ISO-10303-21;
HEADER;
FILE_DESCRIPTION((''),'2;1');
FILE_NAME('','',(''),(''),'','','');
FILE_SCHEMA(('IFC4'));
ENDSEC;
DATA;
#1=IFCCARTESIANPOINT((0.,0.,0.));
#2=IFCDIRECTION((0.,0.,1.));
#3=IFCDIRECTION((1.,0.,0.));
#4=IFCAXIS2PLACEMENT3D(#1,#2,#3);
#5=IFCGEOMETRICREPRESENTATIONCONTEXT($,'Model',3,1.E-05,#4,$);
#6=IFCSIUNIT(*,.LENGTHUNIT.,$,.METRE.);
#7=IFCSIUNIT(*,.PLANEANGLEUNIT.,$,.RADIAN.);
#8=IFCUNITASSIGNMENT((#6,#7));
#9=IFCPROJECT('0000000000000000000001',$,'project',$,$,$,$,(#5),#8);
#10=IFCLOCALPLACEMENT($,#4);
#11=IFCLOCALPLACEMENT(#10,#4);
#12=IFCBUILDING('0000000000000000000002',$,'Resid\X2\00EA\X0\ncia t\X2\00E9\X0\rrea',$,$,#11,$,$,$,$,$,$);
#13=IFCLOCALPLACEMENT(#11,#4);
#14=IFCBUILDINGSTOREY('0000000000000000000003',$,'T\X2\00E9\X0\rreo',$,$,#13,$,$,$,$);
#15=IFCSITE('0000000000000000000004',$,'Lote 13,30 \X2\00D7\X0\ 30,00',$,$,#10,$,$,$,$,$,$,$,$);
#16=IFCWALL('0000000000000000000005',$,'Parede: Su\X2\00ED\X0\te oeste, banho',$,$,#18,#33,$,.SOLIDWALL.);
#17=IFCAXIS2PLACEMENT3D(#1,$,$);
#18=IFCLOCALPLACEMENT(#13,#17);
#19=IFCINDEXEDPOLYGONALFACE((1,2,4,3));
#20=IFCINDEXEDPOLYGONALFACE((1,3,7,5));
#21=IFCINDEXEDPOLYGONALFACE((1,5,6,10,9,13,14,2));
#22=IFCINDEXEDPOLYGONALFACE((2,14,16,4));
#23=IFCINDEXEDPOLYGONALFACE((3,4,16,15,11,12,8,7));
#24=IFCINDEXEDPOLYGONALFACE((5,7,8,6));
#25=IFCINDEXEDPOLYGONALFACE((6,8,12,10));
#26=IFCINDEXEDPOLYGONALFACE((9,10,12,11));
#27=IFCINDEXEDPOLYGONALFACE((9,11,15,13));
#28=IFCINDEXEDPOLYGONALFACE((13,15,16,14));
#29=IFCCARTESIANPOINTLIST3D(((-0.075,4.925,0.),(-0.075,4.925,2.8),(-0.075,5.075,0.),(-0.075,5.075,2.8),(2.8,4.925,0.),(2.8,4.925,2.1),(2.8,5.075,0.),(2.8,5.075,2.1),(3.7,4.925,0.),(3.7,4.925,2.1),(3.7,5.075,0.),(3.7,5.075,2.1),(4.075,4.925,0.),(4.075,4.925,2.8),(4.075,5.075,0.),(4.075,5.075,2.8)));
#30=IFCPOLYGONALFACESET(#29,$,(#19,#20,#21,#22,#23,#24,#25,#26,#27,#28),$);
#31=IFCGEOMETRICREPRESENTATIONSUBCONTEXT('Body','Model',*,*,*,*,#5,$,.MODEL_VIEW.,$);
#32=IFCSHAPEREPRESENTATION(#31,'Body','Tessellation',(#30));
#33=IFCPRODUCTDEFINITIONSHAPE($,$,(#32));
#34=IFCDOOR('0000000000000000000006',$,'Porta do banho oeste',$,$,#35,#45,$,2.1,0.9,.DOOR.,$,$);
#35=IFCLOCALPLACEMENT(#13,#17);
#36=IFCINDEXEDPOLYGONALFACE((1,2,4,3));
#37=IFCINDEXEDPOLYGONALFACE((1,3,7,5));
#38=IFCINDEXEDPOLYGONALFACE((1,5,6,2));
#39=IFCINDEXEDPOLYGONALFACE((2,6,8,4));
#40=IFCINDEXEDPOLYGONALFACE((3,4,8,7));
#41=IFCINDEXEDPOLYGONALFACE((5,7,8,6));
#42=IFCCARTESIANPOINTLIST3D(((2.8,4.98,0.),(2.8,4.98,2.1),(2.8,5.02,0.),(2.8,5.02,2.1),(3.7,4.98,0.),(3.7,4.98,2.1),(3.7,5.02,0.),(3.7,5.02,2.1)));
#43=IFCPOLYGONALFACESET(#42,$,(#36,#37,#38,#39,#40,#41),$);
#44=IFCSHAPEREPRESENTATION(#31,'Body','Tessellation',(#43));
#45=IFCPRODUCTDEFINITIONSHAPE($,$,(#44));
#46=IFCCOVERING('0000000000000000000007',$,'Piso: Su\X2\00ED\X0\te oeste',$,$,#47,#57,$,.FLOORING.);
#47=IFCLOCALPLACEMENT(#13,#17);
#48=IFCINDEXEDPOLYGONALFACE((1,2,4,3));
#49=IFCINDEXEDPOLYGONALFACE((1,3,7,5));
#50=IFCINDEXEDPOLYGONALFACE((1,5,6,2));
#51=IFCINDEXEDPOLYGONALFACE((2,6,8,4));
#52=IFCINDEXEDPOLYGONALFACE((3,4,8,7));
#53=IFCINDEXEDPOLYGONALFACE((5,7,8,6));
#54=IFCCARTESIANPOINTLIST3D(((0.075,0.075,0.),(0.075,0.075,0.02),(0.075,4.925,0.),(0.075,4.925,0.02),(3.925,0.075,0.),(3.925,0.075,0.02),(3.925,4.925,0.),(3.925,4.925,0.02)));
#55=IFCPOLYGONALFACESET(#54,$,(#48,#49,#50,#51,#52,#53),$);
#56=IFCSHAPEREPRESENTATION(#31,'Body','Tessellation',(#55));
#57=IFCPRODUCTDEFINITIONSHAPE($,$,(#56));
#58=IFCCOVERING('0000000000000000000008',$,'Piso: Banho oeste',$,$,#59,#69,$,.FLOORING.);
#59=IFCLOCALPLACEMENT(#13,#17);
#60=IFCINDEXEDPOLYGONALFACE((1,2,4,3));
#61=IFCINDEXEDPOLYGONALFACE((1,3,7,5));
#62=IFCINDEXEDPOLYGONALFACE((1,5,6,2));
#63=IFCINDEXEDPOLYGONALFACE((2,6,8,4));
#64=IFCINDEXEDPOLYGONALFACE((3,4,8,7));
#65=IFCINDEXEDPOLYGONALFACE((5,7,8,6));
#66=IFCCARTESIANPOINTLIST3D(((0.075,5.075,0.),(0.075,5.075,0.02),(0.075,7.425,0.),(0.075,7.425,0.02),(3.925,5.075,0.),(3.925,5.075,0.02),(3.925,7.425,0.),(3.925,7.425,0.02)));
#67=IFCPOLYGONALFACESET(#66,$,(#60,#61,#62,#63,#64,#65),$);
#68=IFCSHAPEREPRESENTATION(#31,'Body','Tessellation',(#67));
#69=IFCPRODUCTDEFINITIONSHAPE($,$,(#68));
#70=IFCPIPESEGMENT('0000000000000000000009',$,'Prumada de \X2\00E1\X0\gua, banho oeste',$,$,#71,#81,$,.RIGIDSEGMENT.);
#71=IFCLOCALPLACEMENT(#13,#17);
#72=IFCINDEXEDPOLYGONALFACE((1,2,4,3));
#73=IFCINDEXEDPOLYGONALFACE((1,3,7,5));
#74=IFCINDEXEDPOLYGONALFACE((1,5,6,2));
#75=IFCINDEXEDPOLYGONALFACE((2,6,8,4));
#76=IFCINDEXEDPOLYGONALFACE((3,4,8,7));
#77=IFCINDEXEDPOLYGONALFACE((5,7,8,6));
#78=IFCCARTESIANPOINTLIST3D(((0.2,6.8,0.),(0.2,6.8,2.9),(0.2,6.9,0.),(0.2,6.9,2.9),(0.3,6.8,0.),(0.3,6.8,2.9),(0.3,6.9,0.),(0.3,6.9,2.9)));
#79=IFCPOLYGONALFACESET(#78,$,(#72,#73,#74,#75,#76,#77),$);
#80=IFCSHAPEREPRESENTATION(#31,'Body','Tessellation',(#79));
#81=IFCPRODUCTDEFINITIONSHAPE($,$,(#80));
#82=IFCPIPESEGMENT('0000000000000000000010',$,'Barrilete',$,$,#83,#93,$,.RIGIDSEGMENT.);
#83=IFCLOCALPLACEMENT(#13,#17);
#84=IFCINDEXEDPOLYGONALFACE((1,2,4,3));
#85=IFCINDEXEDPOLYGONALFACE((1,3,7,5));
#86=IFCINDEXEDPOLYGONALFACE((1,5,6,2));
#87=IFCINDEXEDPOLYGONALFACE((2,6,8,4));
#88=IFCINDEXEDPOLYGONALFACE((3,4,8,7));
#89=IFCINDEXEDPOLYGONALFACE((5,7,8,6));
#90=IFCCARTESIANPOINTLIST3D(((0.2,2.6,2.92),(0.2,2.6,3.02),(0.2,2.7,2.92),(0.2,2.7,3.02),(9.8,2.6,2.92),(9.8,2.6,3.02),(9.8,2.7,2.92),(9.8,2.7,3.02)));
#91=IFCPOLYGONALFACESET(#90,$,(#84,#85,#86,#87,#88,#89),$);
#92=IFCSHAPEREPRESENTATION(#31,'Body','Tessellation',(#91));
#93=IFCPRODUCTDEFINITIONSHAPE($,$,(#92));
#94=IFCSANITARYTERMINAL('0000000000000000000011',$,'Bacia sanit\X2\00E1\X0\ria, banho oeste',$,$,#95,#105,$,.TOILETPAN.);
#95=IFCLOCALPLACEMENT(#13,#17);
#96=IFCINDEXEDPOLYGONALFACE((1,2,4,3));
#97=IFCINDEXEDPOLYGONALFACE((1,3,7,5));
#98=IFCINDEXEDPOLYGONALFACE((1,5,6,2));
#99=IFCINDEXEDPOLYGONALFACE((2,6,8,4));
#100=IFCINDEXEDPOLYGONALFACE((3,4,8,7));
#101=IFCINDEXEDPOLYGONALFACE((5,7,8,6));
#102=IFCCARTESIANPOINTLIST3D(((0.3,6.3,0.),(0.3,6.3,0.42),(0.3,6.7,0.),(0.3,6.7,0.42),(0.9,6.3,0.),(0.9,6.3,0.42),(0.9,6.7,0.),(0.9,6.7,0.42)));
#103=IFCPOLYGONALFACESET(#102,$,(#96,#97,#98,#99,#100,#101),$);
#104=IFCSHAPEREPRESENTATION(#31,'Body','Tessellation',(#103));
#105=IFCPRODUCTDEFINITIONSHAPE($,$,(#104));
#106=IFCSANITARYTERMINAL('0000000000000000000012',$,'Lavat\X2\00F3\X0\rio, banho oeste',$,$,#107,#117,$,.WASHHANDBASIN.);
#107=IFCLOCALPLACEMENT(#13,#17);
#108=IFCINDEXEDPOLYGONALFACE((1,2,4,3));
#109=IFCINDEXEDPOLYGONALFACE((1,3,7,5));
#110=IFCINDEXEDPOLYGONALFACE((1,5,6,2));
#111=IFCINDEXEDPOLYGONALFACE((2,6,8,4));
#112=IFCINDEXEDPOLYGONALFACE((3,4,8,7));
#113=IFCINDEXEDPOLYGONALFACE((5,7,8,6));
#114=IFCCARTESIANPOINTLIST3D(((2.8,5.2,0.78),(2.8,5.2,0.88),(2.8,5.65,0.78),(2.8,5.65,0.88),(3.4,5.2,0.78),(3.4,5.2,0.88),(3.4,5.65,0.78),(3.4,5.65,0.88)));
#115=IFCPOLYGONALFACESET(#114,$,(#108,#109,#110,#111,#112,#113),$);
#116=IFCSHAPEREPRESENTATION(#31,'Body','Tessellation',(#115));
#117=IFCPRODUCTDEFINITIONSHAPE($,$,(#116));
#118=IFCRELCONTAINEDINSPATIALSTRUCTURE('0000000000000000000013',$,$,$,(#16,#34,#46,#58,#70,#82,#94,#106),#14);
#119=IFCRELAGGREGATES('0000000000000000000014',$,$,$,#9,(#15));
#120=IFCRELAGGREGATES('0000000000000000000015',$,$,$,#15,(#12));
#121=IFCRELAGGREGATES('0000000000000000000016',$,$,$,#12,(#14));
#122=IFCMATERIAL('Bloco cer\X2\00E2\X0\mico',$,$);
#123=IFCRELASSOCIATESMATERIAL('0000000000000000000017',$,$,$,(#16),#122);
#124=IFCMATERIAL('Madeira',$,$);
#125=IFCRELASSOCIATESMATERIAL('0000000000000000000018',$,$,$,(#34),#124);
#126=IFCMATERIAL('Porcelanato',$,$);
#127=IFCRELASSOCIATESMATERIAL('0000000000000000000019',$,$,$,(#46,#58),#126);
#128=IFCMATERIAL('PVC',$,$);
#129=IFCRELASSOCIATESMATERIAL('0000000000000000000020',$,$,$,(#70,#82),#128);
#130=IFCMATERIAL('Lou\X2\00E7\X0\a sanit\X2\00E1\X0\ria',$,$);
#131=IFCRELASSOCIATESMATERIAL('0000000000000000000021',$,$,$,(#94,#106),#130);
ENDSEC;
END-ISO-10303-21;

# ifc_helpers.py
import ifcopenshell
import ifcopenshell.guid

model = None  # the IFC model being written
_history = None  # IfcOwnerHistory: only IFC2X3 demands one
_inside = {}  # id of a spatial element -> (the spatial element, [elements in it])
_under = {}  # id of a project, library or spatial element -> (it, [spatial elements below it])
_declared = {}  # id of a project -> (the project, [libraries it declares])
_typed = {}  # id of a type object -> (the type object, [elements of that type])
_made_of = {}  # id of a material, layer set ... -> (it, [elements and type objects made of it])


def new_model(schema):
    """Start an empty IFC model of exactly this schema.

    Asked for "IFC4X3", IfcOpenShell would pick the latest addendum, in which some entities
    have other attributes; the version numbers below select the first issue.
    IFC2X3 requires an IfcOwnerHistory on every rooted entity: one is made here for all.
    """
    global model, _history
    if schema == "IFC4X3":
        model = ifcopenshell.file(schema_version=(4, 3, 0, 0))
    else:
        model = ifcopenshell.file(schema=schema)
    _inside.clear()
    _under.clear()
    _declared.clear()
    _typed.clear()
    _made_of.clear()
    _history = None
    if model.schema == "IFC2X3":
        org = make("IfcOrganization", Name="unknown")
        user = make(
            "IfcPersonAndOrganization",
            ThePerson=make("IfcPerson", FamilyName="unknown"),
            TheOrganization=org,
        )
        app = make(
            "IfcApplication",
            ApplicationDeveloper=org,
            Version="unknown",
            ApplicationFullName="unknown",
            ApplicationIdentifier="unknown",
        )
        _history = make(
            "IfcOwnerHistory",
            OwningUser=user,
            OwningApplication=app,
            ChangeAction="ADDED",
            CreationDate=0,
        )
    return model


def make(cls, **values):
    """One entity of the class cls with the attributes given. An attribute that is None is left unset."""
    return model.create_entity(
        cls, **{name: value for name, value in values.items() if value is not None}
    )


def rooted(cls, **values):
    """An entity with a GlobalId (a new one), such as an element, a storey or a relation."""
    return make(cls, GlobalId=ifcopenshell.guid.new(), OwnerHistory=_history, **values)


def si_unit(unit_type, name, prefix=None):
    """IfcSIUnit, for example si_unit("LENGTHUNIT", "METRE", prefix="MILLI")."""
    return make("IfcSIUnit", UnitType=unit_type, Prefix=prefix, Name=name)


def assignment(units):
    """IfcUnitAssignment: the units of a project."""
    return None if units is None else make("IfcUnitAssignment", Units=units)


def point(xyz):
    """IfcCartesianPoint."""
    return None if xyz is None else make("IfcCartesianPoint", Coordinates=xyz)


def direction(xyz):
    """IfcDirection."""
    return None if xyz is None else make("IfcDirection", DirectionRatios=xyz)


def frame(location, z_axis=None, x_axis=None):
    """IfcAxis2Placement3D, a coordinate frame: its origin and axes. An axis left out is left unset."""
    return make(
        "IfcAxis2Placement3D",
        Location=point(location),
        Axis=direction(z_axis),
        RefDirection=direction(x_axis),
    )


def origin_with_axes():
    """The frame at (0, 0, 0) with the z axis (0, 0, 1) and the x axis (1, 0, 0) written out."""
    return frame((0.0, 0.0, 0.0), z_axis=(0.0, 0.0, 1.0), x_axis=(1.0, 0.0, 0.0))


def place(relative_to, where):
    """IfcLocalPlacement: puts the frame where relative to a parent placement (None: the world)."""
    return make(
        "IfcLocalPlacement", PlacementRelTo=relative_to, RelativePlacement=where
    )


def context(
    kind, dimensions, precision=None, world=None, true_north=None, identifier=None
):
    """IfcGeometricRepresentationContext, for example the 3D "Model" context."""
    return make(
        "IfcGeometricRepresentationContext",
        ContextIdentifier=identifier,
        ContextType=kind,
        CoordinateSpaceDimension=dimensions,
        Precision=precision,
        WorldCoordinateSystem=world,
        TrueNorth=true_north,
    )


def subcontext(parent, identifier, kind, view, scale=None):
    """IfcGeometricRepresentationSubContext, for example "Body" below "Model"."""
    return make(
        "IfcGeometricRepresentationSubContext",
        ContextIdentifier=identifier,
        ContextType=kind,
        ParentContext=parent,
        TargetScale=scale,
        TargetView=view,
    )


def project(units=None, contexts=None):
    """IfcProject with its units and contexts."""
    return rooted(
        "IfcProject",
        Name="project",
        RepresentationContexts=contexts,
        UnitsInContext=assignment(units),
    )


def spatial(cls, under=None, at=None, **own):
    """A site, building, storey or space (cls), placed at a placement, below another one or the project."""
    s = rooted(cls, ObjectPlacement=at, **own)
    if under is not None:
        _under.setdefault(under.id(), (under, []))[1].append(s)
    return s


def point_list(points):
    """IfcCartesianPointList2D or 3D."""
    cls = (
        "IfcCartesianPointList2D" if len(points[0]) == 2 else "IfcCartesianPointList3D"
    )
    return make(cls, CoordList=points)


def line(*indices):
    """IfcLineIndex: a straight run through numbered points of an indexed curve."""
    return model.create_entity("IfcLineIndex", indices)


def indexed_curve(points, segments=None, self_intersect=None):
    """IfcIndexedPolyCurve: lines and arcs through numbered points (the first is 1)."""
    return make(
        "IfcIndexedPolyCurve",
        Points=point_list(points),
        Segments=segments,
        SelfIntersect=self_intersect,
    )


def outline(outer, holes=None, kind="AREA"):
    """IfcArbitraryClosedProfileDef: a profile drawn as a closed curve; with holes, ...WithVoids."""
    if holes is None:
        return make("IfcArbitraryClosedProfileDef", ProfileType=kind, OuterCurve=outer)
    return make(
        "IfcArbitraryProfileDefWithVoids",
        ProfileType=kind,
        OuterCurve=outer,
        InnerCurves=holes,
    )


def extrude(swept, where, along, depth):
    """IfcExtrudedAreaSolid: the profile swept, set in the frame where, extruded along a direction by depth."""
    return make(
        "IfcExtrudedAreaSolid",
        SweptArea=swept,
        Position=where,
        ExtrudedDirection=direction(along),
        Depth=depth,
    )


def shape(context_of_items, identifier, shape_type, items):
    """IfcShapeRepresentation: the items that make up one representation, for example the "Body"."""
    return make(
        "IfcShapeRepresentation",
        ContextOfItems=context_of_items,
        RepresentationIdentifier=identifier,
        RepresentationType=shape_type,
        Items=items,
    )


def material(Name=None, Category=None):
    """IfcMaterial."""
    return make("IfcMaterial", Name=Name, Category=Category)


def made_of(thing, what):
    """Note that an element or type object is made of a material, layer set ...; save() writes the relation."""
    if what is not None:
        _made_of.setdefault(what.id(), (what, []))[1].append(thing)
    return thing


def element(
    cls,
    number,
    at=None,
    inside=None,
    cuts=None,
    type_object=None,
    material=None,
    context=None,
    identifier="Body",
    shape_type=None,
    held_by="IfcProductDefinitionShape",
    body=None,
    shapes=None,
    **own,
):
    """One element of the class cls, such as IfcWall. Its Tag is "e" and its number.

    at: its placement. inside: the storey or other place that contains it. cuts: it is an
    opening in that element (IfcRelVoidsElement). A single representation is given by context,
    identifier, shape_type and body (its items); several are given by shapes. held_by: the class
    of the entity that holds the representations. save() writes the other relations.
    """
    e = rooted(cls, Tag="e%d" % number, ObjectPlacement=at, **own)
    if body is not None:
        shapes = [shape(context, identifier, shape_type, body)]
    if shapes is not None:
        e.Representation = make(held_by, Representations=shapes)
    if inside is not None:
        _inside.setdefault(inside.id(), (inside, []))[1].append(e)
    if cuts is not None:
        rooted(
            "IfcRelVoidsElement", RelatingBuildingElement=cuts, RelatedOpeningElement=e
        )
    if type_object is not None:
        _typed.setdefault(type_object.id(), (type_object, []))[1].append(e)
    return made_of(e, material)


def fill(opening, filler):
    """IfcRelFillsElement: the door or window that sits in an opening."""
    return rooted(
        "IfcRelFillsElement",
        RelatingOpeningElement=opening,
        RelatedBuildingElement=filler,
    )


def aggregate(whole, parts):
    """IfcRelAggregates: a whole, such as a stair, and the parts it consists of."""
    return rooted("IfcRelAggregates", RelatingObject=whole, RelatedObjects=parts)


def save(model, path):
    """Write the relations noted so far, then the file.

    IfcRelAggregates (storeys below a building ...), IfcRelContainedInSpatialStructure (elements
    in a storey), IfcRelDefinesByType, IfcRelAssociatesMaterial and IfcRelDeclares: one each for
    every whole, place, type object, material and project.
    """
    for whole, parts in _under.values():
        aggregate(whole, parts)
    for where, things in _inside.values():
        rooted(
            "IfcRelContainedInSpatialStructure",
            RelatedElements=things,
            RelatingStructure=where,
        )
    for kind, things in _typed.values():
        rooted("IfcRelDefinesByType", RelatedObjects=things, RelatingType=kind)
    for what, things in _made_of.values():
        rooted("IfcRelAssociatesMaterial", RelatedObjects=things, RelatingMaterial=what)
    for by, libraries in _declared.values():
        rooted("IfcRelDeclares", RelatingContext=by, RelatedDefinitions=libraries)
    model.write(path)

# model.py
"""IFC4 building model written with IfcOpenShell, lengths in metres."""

from ifc_helpers import new_model, si_unit, frame, origin_with_axes, place, context, subcontext, project, spatial, line, indexed_curve, outline, extrude, material, element, fill, save


model = new_model("IFC4")

# Units and contexts
model_context = context("Model", 3, precision=1e-05, world=origin_with_axes())
body_context = subcontext(model_context, "Body", "Model", "MODEL_VIEW")
ifc_project = project(units=[si_unit("LENGTHUNIT", "METRE"), si_unit("PLANEANGLEUNIT", "RADIAN")], contexts=[model_context])

# Site, building, storey
site_placement = place(None, origin_with_axes())
site = spatial("IfcSite", under=ifc_project, at=site_placement, Name="Lote 13,30 × 30,00")
building_placement = place(site_placement, origin_with_axes())
building = spatial("IfcBuilding", under=site, at=building_placement, Name="Residência térrea")
storey_placement = place(building_placement, origin_with_axes())
storey = spatial("IfcBuildingStorey", under=building, at=storey_placement, Name="Térreo")

# Shared definitions
ifc_material_1 = material(Name="Concreto armado")

# Shared definitions
ifc_material_2 = material(Name="Bloco cerâmico")
ifc_material_3 = material(Name="Madeira")

# Wall, opening, door
wall_1_placement = place(storey_placement, frame((-0.075, 4.925, 0.0), z_axis=(0.0, 0.0, 1.0), x_axis=(1.0, 0.0, 0.0)))
wall_1 = element("IfcWall", 1, at=wall_1_placement, inside=storey, material=ifc_material_2, Name="Parede: Suíte oeste, banho", PredefinedType="SOLIDWALL", context=body_context, shape_type="SweptSolid", body=[
    extrude(outline(indexed_curve([(0.0, 0.0), (4.15, 0.0), (4.15, 0.15), (0.0, 0.15)], segments=[line(1, 2, 3, 4, 1)])), origin_with_axes(), (0.0, 0.0, 1.0), 2.8),
])
opening_1_placement = place(wall_1_placement, frame((2.875, -0.05, 0.0), z_axis=(0.0, 0.0, 1.0), x_axis=(1.0, 0.0, 0.0)))
opening_1 = element("IfcOpeningElement", 2, at=opening_1_placement, cuts=wall_1, material=ifc_material_1, PredefinedType="OPENING", context=body_context, shape_type="SweptSolid", body=[
    extrude(outline(indexed_curve([(0.0, 0.0), (0.9, 0.0), (0.9, 0.25), (0.0, 0.25)], segments=[line(1, 2, 3, 4, 1)])), origin_with_axes(), (0.0, 0.0, 1.0), 2.1),
])
door_1_placement = place(storey_placement, frame((2.8, 4.98, 0.0), z_axis=(0.0, 0.0, 1.0), x_axis=(1.0, 0.0, 0.0)))
door_1 = element("IfcDoor", 3, at=door_1_placement, inside=storey, material=ifc_material_3, Name="Porta do banho oeste", OverallHeight=2.1, OverallWidth=0.9, PredefinedType="DOOR", context=body_context, shape_type="SweptSolid", body=[
    extrude(outline(indexed_curve([(0.0, 0.0), (0.9, 0.0), (0.9, 0.04), (0.0, 0.04)], segments=[line(1, 2, 3, 4, 1)])), origin_with_axes(), (0.0, 0.0, 1.0), 2.1),
])
fill(opening_1, door_1)

# Coverings
ifc_material_4 = material(Name="Porcelanato")
covering_1_placement = place(storey_placement, frame((0.075, 0.075, 0.0), z_axis=(0.0, 0.0, 1.0), x_axis=(1.0, 0.0, 0.0)))
element("IfcCovering", 4, at=covering_1_placement, inside=storey, material=ifc_material_4, Name="Piso: Suíte oeste", PredefinedType="FLOORING", context=body_context, shape_type="SweptSolid", body=[
    extrude(outline(indexed_curve([(0.0, 0.0), (3.85, 0.0), (3.85, 4.85), (0.0, 4.85)], segments=[line(1, 2, 3, 4, 1)])), origin_with_axes(), (0.0, 0.0, 1.0), 0.02),
])
covering_2_placement = place(storey_placement, frame((0.075, 5.075, 0.0), z_axis=(0.0, 0.0, 1.0), x_axis=(1.0, 0.0, 0.0)))
element("IfcCovering", 5, at=covering_2_placement, inside=storey, material=ifc_material_4, Name="Piso: Banho oeste", PredefinedType="FLOORING", context=body_context, shape_type="SweptSolid", body=[
    extrude(outline(indexed_curve([(0.0, 0.0), (3.85, 0.0), (3.85, 2.35), (0.0, 2.35)], segments=[line(1, 2, 3, 4, 1)])), origin_with_axes(), (0.0, 0.0, 1.0), 0.02),
])

# Pipe segments
ifc_material_5 = material(Name="PVC")
pipe_segment_1_placement = place(storey_placement, frame((0.2, 6.8, 0.0), z_axis=(0.0, 0.0, 1.0), x_axis=(1.0, 0.0, 0.0)))
element("IfcPipeSegment", 6, at=pipe_segment_1_placement, inside=storey, material=ifc_material_5, Name="Prumada de água, banho oeste", PredefinedType="RIGIDSEGMENT", context=body_context, shape_type="SweptSolid", body=[
    extrude(outline(indexed_curve([(0.0, 0.0), (0.1, 0.0), (0.1, 0.1), (0.0, 0.1)], segments=[line(1, 2, 3, 4, 1)])), origin_with_axes(), (0.0, 0.0, 1.0), 2.9),
])
pipe_segment_2_placement = place(storey_placement, frame((0.2, 2.6, 2.92), z_axis=(0.0, 0.0, 1.0), x_axis=(1.0, 0.0, 0.0)))
element("IfcPipeSegment", 7, at=pipe_segment_2_placement, inside=storey, material=ifc_material_5, Name="Barrilete", PredefinedType="RIGIDSEGMENT", context=body_context, shape_type="SweptSolid", body=[
    extrude(outline(indexed_curve([(0.0, 0.0), (9.6, 0.0), (9.6, 0.1), (0.0, 0.1)], segments=[line(1, 2, 3, 4, 1)])), origin_with_axes(), (0.0, 0.0, 1.0), 0.1),
])

# Sanitary terminals
ifc_material_6 = material(Name="Louça sanitária")
sanitary_terminal_1_placement = place(storey_placement, frame((0.3, 6.3, 0.0), z_axis=(0.0, 0.0, 1.0), x_axis=(1.0, 0.0, 0.0)))
element("IfcSanitaryTerminal", 8, at=sanitary_terminal_1_placement, inside=storey, material=ifc_material_6, Name="Bacia sanitária, banho oeste", PredefinedType="TOILETPAN", context=body_context, shape_type="SweptSolid", body=[
    extrude(outline(indexed_curve([(0.0, 0.0), (0.6, 0.0), (0.6, 0.4), (0.0, 0.4)], segments=[line(1, 2, 3, 4, 1)])), origin_with_axes(), (0.0, 0.0, 1.0), 0.42),
])
sanitary_terminal_2_placement = place(storey_placement, frame((2.8, 5.2, 0.78), z_axis=(0.0, 0.0, 1.0), x_axis=(1.0, 0.0, 0.0)))
element("IfcSanitaryTerminal", 9, at=sanitary_terminal_2_placement, inside=storey, material=ifc_material_6, Name="Lavatório, banho oeste", PredefinedType="WASHHANDBASIN", context=body_context, shape_type="SweptSolid", body=[
    extrude(outline(indexed_curve([(0.0, 0.0), (0.6, 0.0), (0.6, 0.45), (0.0, 0.45)], segments=[line(1, 2, 3, 4, 1)])), origin_with_axes(), (0.0, 0.0, 1.0), 0.1),
])

save(model, "model.ifc")
